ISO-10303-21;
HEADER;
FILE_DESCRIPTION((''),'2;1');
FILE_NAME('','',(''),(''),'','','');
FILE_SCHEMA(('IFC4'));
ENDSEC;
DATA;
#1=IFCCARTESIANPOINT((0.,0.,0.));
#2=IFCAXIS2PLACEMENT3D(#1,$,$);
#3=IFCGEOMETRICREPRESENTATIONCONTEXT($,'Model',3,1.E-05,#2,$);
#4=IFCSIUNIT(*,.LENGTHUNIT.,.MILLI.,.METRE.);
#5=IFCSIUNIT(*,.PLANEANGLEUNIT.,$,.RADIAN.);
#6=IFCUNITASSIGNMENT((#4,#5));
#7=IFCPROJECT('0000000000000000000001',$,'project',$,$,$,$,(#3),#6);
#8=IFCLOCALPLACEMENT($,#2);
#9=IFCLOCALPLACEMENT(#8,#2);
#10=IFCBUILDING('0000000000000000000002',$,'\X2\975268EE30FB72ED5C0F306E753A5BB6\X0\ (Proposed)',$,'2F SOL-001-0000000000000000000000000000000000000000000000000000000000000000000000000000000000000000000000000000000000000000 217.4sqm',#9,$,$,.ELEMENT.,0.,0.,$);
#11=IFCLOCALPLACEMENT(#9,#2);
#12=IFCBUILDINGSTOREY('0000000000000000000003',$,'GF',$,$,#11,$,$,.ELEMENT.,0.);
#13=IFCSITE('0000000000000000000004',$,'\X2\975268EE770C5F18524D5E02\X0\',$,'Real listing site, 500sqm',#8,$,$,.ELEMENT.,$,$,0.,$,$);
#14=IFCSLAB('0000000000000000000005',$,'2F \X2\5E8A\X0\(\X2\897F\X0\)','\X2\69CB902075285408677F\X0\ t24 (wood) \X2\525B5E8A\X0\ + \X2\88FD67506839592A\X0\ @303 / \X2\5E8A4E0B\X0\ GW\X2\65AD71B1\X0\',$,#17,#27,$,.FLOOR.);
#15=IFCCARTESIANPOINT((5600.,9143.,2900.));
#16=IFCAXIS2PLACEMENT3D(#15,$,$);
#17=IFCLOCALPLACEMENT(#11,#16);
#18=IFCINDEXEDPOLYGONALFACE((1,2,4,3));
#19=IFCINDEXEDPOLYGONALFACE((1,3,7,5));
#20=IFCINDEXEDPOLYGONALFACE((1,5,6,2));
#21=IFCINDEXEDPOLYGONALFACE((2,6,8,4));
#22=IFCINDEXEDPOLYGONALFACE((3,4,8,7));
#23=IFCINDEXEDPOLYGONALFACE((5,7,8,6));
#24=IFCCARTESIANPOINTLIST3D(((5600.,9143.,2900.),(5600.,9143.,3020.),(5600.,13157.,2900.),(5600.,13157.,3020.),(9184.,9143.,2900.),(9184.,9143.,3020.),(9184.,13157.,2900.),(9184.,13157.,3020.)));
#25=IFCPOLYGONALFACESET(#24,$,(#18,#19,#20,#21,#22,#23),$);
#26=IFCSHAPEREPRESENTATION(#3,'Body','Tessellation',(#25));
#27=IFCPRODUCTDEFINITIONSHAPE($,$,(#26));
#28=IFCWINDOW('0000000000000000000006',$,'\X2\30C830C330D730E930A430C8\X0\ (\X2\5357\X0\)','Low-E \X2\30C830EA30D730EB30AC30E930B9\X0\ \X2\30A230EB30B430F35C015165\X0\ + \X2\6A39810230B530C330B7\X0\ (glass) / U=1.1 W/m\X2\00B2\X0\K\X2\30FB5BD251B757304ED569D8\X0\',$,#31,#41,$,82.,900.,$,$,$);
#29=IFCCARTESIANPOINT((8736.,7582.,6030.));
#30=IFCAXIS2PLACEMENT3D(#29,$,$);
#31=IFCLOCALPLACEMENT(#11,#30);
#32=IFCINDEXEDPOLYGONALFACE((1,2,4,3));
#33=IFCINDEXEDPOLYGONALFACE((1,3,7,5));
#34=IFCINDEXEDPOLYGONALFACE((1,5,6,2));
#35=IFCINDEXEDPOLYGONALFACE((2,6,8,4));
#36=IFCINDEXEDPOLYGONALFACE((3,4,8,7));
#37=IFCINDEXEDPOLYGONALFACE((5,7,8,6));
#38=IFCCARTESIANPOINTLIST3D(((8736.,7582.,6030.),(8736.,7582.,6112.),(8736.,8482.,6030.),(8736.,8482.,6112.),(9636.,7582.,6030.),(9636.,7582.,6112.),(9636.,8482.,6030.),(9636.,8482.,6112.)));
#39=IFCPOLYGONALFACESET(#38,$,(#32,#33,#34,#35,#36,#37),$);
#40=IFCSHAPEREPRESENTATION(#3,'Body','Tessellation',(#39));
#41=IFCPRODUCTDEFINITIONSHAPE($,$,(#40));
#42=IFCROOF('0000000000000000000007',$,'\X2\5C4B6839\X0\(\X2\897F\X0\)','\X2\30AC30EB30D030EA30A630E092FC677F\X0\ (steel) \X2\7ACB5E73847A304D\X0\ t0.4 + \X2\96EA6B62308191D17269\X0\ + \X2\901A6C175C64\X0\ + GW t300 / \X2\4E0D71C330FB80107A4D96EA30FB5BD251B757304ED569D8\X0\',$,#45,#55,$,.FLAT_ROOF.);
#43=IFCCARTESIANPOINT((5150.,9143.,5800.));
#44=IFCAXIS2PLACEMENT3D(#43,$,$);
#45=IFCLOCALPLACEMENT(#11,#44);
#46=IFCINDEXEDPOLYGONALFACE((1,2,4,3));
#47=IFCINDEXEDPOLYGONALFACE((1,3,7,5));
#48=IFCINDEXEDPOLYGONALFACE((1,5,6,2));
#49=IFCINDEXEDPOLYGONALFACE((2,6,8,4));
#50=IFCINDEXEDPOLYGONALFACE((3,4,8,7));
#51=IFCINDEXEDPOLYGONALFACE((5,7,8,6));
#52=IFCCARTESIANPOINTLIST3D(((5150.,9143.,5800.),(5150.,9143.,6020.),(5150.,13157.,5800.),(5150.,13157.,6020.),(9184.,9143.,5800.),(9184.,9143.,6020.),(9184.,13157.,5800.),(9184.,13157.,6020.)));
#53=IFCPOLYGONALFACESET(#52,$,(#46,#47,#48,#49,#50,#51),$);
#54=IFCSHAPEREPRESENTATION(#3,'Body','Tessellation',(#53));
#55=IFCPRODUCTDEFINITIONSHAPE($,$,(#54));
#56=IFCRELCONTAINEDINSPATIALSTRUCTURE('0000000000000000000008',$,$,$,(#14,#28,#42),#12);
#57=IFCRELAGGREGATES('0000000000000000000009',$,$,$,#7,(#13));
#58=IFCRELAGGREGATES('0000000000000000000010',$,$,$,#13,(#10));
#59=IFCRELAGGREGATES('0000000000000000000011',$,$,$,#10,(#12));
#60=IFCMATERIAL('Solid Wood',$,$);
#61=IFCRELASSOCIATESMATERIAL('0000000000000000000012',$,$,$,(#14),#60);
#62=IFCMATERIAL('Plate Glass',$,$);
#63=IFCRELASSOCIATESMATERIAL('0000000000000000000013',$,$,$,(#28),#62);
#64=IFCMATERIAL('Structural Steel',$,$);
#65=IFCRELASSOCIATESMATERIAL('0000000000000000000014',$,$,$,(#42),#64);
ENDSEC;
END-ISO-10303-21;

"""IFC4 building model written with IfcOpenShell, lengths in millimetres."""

from ifc_helpers import new_model, si_unit, frame, frame_2d, origin, place, context, project, spatial, rectangle, extrude, material, element, save


model = new_model("IFC4")

# Units and contexts
model_context = context("Model", 3, precision=1e-05, world=origin())
ifc_project = project(units=[si_unit("LENGTHUNIT", "METRE", prefix="MILLI"), si_unit("PLANEANGLEUNIT", "RADIAN")], contexts=[model_context])

# Site, building, storey
site_placement = place(None, origin())
site = spatial("IfcSite", under=ifc_project, at=site_placement, Name="青森県弘前市", ObjectType="Real listing site, 500sqm", CompositionType="ELEMENT", RefElevation=0.0)
building_placement = place(site_placement, origin())
building = spatial("IfcBuilding", under=site, at=building_placement, Name="青森・狭小の町家 (Proposed)", ObjectType="2F SOL-001-0000000000000000000000000000000000000000000000000000000000000000000000000000000000000000000000000000000000000000 217.4sqm", CompositionType="ELEMENT", ElevationOfRefHeight=0.0, ElevationOfTerrain=0.0)
storey_placement = place(building_placement, origin())
storey = spatial("IfcBuildingStorey", under=building, at=storey_placement, Name="GF", CompositionType="ELEMENT", Elevation=0.0)

# Shared definitions
ifc_material_1 = material(Name="Solid Wood")

# Slab
slab_1_placement = place(storey_placement, frame((5600.0, 9143.0, 2900.0)))
element("IfcSlab", 1, at=slab_1_placement, inside=storey, material=ifc_material_1, Name="2F 床(西)", Description="構造用合板 t24 (wood) 剛床 + 製材根太 @303 / 床下 GW断熱", PredefinedType="FLOOR", context=model_context, shape_type="SweptSolid", body=[
    extrude(rectangle(XDim=3584.0, YDim=4014.0, at=frame_2d((1792.0, 2007.0))), frame((5600.0, 9143.0, 2900.0)), (0.0, 0.0, 1.0), 120.0),
])

# Window
ifc_material_2 = material(Name="Plate Glass")
window_placement = place(storey_placement, frame((8736.0, 7582.0, 6030.0)))
element("IfcWindow", 2, at=window_placement, inside=storey, material=ifc_material_2, Name="トップライト (南)", Description="Low-E トリプルガラス アルゴン封入 + 樹脂サッシ (glass) / U=1.1 W/m²K・寒冷地仕様", OverallHeight=82.0, OverallWidth=900.0, context=model_context, shape_type="SweptSolid", body=[
    extrude(rectangle(XDim=900.0, YDim=900.0, at=frame_2d((450.0, 450.0))), frame((8736.0, 7582.0, 6030.0)), (0.0, 0.0, 1.0), 82.0),
])

# Roof
ifc_material_3 = material(Name="Structural Steel")
for number, where, name in (
    (3, (5150.0, 9143.0, 5800.0), "屋根(西)"),
):
    element("IfcRoof", number, at=place(storey_placement, frame(where)), inside=storey, material=ifc_material_3, Name=name, Description="ガルバリウム鋼板 (steel) 立平葺き t0.4 + 雪止め金物 + 通気層 + GW t300 / 不燃・耐積雪・寒冷地仕様", PredefinedType="FLAT_ROOF", context=model_context, shape_type="SweptSolid", body=[
        extrude(rectangle(XDim=4034.0, YDim=4014.0, at=frame_2d((2017.0, 2007.0))), frame((5150.0, 9143.0, 5800.0)), (0.0, 0.0, 1.0), 220.0),
    ])

save(model, "model.ifc")
